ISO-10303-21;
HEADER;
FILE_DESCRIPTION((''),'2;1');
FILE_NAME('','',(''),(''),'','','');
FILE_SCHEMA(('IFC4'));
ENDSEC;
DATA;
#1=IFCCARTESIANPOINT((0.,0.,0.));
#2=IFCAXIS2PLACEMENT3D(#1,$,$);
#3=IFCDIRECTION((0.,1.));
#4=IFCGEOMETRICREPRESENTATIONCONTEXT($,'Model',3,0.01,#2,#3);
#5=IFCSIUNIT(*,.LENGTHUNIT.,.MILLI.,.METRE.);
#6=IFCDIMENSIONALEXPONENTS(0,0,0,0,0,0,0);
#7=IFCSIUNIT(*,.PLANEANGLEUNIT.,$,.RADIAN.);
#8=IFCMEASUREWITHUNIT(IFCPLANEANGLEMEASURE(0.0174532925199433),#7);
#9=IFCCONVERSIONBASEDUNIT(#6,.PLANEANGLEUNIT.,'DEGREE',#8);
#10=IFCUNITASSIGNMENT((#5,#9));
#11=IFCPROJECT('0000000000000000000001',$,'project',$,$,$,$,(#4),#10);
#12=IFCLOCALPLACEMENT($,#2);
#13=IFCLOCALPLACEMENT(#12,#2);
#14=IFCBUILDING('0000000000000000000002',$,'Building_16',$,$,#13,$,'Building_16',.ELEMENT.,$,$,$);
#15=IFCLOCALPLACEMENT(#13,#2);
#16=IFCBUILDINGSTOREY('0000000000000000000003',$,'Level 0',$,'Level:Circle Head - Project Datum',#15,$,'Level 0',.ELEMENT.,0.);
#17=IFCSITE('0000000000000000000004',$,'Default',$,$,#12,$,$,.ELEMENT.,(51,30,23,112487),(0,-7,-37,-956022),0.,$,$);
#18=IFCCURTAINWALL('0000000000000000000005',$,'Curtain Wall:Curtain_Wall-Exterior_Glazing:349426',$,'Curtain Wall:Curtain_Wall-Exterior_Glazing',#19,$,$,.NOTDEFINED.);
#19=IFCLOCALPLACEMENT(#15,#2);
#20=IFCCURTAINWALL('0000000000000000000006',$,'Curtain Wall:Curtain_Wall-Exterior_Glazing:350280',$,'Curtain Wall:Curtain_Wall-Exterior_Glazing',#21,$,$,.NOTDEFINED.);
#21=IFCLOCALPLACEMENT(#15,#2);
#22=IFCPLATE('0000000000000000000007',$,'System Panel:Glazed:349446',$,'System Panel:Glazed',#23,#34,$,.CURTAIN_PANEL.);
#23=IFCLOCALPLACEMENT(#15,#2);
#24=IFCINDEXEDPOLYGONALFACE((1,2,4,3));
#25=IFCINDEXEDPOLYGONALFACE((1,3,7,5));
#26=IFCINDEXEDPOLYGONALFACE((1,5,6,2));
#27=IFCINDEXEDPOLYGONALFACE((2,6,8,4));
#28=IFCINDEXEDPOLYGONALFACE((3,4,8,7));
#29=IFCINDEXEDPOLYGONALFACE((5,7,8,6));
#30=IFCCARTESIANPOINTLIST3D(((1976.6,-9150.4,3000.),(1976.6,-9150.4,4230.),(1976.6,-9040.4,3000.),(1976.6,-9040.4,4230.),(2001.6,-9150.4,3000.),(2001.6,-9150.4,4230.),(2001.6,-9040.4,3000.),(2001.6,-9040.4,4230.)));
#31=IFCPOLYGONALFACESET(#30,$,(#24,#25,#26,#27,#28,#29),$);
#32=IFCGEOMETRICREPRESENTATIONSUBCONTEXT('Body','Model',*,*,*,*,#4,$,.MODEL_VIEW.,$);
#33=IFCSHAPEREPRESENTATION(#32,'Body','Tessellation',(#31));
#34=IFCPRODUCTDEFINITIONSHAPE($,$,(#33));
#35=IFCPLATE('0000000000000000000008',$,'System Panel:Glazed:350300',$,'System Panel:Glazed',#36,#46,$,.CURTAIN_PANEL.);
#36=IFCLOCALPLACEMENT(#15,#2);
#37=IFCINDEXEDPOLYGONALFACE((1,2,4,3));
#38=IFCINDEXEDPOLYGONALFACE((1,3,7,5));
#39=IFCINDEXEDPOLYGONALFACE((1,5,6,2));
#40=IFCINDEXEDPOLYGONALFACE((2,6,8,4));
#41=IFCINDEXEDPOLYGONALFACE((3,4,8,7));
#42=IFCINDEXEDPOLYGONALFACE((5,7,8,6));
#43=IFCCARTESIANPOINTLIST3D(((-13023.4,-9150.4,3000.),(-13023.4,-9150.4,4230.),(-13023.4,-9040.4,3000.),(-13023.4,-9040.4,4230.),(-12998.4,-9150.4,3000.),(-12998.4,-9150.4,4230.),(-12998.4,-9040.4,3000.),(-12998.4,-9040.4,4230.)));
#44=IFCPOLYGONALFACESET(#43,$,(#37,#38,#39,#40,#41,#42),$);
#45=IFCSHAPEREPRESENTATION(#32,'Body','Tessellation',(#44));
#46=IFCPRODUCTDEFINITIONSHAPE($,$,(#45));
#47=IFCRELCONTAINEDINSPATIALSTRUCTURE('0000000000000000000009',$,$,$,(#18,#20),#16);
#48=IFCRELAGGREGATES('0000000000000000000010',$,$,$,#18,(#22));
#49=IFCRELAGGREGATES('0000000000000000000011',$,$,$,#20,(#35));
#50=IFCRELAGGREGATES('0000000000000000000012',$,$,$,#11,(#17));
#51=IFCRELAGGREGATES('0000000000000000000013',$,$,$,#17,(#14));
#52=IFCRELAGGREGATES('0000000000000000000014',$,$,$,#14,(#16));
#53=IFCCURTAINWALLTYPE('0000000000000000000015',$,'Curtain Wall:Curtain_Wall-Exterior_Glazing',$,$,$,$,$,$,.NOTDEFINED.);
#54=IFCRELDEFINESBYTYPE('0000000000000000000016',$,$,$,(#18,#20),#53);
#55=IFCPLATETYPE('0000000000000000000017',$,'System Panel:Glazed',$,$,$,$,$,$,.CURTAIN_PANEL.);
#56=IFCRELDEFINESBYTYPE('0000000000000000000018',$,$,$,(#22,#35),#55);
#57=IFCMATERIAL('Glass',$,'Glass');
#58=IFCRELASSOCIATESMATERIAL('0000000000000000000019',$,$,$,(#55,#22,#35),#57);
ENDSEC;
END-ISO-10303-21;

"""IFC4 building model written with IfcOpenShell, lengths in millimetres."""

from ifc_helpers import new_model, entity, si_unit, converted_unit, direction, frame, origin, place, context, subcontext, project, spatial, indexed_curve, outline, extrude, source, transform, mapped, material, type_object, type_shapes, element, aggregate, save


model = new_model("IFC4")

# Units and contexts
model_context = context("Model", 3, precision=0.01, world=origin(), true_north=direction((0.0, 1.0)))
body_context = subcontext(model_context, "Body", "Model", "MODEL_VIEW")
ifc_project = project(units=[si_unit("LENGTHUNIT", "METRE", prefix="MILLI"), converted_unit("PLANEANGLEUNIT", "DEGREE", entity("IfcPlaneAngleMeasure", 0.0174532925199433), si_unit("PLANEANGLEUNIT", "RADIAN"), dimensions=[0, 0, 0, 0, 0, 0, 0])], contexts=[model_context])

# Site, building, storey
site_placement = place(None, origin())
site = spatial("IfcSite", under=ifc_project, at=site_placement, Name="Default", CompositionType="ELEMENT", RefLatitude=(51, 30, 23, 112487), RefLongitude=(0, -7, -37, -956022), RefElevation=0.0)
building_placement = place(site_placement, origin())
building = spatial("IfcBuilding", under=site, at=building_placement, Name="Building_16", LongName="Building_16", CompositionType="ELEMENT")
storey_placement = place(building_placement, origin())
storey = spatial("IfcBuildingStorey", under=building, at=storey_placement, Name="Level 0", ObjectType="Level:Circle Head - Project Datum", LongName="Level 0", CompositionType="ELEMENT", Elevation=0.0)

# Curtain walls
curtain_wall_type = type_object("IfcCurtainWallType", Name="Curtain Wall:Curtain_Wall-Exterior_Glazing", PredefinedType="NOTDEFINED")
curtain_wall_1_placement = place(storey_placement, origin())
curtain_wall_1 = element("IfcCurtainWall", 1, at=curtain_wall_1_placement, inside=storey, type_object=curtain_wall_type, Name="Curtain Wall:Curtain_Wall-Exterior_Glazing:349426", ObjectType="Curtain Wall:Curtain_Wall-Exterior_Glazing", PredefinedType="NOTDEFINED")
ifc_material_1 = material(Name="Glass", Category="Glass")
curtain_wall_2_placement = place(storey_placement, origin())
curtain_wall_2 = element("IfcCurtainWall", 2, at=curtain_wall_2_placement, inside=storey, type_object=curtain_wall_type, Name="Curtain Wall:Curtain_Wall-Exterior_Glazing:350280", ObjectType="Curtain Wall:Curtain_Wall-Exterior_Glazing", PredefinedType="NOTDEFINED")

# Plates
plate_type_1 = type_object("IfcPlateType", Name="System Panel:Glazed", PredefinedType="CURTAIN_PANEL", material=ifc_material_1)
shared_shape_1 = source(origin(), body_context, "Body", "SweptSolid", [
    extrude(outline(indexed_curve([(-12.5, -55.0), (12.5, -55.0), (12.5, 55.0), (-12.5, 55.0), (-12.5, -55.0)], self_intersect=False)), frame((0.0, 37.0, 0.0), z_axis=(0.0, 0.0, 1.0), x_axis=(0.0, 1.0, 0.0)), (0.0, 0.0, 1.0), 1230.0),
])
type_shapes(plate_type_1, [shared_shape_1])
plate_1_placement = place(curtain_wall_1_placement, frame((2026.1, -9095.4, 3000.0), z_axis=(0.0, 0.0, 1.0), x_axis=(0.0, 1.0, 0.0)))
plate_1 = element("IfcPlate", 3, at=plate_1_placement, type_object=plate_type_1, material=ifc_material_1, Name="System Panel:Glazed:349446", ObjectType="System Panel:Glazed", PredefinedType="CURTAIN_PANEL", context=body_context, shape_type="MappedRepresentation", body=[
    mapped(shared_shape_1, transform((0.0, 0.0, 0.0), scale=1.0)),
])
aggregate(curtain_wall_1, [plate_1])
plate_2_placement = place(curtain_wall_2_placement, frame((-12973.9, -9095.4, 3000.0), z_axis=(0.0, 0.0, 1.0), x_axis=(0.0, 1.0, 0.0)))
plate_2 = element("IfcPlate", 4, at=plate_2_placement, type_object=plate_type_1, material=ifc_material_1, Name="System Panel:Glazed:350300", ObjectType="System Panel:Glazed", PredefinedType="CURTAIN_PANEL", context=body_context, shape_type="MappedRepresentation", body=[
    mapped(shared_shape_1, transform((0.0, 0.0, 0.0), scale=1.0)),
])
aggregate(curtain_wall_2, [plate_2])

save(model, "model.ifc")
